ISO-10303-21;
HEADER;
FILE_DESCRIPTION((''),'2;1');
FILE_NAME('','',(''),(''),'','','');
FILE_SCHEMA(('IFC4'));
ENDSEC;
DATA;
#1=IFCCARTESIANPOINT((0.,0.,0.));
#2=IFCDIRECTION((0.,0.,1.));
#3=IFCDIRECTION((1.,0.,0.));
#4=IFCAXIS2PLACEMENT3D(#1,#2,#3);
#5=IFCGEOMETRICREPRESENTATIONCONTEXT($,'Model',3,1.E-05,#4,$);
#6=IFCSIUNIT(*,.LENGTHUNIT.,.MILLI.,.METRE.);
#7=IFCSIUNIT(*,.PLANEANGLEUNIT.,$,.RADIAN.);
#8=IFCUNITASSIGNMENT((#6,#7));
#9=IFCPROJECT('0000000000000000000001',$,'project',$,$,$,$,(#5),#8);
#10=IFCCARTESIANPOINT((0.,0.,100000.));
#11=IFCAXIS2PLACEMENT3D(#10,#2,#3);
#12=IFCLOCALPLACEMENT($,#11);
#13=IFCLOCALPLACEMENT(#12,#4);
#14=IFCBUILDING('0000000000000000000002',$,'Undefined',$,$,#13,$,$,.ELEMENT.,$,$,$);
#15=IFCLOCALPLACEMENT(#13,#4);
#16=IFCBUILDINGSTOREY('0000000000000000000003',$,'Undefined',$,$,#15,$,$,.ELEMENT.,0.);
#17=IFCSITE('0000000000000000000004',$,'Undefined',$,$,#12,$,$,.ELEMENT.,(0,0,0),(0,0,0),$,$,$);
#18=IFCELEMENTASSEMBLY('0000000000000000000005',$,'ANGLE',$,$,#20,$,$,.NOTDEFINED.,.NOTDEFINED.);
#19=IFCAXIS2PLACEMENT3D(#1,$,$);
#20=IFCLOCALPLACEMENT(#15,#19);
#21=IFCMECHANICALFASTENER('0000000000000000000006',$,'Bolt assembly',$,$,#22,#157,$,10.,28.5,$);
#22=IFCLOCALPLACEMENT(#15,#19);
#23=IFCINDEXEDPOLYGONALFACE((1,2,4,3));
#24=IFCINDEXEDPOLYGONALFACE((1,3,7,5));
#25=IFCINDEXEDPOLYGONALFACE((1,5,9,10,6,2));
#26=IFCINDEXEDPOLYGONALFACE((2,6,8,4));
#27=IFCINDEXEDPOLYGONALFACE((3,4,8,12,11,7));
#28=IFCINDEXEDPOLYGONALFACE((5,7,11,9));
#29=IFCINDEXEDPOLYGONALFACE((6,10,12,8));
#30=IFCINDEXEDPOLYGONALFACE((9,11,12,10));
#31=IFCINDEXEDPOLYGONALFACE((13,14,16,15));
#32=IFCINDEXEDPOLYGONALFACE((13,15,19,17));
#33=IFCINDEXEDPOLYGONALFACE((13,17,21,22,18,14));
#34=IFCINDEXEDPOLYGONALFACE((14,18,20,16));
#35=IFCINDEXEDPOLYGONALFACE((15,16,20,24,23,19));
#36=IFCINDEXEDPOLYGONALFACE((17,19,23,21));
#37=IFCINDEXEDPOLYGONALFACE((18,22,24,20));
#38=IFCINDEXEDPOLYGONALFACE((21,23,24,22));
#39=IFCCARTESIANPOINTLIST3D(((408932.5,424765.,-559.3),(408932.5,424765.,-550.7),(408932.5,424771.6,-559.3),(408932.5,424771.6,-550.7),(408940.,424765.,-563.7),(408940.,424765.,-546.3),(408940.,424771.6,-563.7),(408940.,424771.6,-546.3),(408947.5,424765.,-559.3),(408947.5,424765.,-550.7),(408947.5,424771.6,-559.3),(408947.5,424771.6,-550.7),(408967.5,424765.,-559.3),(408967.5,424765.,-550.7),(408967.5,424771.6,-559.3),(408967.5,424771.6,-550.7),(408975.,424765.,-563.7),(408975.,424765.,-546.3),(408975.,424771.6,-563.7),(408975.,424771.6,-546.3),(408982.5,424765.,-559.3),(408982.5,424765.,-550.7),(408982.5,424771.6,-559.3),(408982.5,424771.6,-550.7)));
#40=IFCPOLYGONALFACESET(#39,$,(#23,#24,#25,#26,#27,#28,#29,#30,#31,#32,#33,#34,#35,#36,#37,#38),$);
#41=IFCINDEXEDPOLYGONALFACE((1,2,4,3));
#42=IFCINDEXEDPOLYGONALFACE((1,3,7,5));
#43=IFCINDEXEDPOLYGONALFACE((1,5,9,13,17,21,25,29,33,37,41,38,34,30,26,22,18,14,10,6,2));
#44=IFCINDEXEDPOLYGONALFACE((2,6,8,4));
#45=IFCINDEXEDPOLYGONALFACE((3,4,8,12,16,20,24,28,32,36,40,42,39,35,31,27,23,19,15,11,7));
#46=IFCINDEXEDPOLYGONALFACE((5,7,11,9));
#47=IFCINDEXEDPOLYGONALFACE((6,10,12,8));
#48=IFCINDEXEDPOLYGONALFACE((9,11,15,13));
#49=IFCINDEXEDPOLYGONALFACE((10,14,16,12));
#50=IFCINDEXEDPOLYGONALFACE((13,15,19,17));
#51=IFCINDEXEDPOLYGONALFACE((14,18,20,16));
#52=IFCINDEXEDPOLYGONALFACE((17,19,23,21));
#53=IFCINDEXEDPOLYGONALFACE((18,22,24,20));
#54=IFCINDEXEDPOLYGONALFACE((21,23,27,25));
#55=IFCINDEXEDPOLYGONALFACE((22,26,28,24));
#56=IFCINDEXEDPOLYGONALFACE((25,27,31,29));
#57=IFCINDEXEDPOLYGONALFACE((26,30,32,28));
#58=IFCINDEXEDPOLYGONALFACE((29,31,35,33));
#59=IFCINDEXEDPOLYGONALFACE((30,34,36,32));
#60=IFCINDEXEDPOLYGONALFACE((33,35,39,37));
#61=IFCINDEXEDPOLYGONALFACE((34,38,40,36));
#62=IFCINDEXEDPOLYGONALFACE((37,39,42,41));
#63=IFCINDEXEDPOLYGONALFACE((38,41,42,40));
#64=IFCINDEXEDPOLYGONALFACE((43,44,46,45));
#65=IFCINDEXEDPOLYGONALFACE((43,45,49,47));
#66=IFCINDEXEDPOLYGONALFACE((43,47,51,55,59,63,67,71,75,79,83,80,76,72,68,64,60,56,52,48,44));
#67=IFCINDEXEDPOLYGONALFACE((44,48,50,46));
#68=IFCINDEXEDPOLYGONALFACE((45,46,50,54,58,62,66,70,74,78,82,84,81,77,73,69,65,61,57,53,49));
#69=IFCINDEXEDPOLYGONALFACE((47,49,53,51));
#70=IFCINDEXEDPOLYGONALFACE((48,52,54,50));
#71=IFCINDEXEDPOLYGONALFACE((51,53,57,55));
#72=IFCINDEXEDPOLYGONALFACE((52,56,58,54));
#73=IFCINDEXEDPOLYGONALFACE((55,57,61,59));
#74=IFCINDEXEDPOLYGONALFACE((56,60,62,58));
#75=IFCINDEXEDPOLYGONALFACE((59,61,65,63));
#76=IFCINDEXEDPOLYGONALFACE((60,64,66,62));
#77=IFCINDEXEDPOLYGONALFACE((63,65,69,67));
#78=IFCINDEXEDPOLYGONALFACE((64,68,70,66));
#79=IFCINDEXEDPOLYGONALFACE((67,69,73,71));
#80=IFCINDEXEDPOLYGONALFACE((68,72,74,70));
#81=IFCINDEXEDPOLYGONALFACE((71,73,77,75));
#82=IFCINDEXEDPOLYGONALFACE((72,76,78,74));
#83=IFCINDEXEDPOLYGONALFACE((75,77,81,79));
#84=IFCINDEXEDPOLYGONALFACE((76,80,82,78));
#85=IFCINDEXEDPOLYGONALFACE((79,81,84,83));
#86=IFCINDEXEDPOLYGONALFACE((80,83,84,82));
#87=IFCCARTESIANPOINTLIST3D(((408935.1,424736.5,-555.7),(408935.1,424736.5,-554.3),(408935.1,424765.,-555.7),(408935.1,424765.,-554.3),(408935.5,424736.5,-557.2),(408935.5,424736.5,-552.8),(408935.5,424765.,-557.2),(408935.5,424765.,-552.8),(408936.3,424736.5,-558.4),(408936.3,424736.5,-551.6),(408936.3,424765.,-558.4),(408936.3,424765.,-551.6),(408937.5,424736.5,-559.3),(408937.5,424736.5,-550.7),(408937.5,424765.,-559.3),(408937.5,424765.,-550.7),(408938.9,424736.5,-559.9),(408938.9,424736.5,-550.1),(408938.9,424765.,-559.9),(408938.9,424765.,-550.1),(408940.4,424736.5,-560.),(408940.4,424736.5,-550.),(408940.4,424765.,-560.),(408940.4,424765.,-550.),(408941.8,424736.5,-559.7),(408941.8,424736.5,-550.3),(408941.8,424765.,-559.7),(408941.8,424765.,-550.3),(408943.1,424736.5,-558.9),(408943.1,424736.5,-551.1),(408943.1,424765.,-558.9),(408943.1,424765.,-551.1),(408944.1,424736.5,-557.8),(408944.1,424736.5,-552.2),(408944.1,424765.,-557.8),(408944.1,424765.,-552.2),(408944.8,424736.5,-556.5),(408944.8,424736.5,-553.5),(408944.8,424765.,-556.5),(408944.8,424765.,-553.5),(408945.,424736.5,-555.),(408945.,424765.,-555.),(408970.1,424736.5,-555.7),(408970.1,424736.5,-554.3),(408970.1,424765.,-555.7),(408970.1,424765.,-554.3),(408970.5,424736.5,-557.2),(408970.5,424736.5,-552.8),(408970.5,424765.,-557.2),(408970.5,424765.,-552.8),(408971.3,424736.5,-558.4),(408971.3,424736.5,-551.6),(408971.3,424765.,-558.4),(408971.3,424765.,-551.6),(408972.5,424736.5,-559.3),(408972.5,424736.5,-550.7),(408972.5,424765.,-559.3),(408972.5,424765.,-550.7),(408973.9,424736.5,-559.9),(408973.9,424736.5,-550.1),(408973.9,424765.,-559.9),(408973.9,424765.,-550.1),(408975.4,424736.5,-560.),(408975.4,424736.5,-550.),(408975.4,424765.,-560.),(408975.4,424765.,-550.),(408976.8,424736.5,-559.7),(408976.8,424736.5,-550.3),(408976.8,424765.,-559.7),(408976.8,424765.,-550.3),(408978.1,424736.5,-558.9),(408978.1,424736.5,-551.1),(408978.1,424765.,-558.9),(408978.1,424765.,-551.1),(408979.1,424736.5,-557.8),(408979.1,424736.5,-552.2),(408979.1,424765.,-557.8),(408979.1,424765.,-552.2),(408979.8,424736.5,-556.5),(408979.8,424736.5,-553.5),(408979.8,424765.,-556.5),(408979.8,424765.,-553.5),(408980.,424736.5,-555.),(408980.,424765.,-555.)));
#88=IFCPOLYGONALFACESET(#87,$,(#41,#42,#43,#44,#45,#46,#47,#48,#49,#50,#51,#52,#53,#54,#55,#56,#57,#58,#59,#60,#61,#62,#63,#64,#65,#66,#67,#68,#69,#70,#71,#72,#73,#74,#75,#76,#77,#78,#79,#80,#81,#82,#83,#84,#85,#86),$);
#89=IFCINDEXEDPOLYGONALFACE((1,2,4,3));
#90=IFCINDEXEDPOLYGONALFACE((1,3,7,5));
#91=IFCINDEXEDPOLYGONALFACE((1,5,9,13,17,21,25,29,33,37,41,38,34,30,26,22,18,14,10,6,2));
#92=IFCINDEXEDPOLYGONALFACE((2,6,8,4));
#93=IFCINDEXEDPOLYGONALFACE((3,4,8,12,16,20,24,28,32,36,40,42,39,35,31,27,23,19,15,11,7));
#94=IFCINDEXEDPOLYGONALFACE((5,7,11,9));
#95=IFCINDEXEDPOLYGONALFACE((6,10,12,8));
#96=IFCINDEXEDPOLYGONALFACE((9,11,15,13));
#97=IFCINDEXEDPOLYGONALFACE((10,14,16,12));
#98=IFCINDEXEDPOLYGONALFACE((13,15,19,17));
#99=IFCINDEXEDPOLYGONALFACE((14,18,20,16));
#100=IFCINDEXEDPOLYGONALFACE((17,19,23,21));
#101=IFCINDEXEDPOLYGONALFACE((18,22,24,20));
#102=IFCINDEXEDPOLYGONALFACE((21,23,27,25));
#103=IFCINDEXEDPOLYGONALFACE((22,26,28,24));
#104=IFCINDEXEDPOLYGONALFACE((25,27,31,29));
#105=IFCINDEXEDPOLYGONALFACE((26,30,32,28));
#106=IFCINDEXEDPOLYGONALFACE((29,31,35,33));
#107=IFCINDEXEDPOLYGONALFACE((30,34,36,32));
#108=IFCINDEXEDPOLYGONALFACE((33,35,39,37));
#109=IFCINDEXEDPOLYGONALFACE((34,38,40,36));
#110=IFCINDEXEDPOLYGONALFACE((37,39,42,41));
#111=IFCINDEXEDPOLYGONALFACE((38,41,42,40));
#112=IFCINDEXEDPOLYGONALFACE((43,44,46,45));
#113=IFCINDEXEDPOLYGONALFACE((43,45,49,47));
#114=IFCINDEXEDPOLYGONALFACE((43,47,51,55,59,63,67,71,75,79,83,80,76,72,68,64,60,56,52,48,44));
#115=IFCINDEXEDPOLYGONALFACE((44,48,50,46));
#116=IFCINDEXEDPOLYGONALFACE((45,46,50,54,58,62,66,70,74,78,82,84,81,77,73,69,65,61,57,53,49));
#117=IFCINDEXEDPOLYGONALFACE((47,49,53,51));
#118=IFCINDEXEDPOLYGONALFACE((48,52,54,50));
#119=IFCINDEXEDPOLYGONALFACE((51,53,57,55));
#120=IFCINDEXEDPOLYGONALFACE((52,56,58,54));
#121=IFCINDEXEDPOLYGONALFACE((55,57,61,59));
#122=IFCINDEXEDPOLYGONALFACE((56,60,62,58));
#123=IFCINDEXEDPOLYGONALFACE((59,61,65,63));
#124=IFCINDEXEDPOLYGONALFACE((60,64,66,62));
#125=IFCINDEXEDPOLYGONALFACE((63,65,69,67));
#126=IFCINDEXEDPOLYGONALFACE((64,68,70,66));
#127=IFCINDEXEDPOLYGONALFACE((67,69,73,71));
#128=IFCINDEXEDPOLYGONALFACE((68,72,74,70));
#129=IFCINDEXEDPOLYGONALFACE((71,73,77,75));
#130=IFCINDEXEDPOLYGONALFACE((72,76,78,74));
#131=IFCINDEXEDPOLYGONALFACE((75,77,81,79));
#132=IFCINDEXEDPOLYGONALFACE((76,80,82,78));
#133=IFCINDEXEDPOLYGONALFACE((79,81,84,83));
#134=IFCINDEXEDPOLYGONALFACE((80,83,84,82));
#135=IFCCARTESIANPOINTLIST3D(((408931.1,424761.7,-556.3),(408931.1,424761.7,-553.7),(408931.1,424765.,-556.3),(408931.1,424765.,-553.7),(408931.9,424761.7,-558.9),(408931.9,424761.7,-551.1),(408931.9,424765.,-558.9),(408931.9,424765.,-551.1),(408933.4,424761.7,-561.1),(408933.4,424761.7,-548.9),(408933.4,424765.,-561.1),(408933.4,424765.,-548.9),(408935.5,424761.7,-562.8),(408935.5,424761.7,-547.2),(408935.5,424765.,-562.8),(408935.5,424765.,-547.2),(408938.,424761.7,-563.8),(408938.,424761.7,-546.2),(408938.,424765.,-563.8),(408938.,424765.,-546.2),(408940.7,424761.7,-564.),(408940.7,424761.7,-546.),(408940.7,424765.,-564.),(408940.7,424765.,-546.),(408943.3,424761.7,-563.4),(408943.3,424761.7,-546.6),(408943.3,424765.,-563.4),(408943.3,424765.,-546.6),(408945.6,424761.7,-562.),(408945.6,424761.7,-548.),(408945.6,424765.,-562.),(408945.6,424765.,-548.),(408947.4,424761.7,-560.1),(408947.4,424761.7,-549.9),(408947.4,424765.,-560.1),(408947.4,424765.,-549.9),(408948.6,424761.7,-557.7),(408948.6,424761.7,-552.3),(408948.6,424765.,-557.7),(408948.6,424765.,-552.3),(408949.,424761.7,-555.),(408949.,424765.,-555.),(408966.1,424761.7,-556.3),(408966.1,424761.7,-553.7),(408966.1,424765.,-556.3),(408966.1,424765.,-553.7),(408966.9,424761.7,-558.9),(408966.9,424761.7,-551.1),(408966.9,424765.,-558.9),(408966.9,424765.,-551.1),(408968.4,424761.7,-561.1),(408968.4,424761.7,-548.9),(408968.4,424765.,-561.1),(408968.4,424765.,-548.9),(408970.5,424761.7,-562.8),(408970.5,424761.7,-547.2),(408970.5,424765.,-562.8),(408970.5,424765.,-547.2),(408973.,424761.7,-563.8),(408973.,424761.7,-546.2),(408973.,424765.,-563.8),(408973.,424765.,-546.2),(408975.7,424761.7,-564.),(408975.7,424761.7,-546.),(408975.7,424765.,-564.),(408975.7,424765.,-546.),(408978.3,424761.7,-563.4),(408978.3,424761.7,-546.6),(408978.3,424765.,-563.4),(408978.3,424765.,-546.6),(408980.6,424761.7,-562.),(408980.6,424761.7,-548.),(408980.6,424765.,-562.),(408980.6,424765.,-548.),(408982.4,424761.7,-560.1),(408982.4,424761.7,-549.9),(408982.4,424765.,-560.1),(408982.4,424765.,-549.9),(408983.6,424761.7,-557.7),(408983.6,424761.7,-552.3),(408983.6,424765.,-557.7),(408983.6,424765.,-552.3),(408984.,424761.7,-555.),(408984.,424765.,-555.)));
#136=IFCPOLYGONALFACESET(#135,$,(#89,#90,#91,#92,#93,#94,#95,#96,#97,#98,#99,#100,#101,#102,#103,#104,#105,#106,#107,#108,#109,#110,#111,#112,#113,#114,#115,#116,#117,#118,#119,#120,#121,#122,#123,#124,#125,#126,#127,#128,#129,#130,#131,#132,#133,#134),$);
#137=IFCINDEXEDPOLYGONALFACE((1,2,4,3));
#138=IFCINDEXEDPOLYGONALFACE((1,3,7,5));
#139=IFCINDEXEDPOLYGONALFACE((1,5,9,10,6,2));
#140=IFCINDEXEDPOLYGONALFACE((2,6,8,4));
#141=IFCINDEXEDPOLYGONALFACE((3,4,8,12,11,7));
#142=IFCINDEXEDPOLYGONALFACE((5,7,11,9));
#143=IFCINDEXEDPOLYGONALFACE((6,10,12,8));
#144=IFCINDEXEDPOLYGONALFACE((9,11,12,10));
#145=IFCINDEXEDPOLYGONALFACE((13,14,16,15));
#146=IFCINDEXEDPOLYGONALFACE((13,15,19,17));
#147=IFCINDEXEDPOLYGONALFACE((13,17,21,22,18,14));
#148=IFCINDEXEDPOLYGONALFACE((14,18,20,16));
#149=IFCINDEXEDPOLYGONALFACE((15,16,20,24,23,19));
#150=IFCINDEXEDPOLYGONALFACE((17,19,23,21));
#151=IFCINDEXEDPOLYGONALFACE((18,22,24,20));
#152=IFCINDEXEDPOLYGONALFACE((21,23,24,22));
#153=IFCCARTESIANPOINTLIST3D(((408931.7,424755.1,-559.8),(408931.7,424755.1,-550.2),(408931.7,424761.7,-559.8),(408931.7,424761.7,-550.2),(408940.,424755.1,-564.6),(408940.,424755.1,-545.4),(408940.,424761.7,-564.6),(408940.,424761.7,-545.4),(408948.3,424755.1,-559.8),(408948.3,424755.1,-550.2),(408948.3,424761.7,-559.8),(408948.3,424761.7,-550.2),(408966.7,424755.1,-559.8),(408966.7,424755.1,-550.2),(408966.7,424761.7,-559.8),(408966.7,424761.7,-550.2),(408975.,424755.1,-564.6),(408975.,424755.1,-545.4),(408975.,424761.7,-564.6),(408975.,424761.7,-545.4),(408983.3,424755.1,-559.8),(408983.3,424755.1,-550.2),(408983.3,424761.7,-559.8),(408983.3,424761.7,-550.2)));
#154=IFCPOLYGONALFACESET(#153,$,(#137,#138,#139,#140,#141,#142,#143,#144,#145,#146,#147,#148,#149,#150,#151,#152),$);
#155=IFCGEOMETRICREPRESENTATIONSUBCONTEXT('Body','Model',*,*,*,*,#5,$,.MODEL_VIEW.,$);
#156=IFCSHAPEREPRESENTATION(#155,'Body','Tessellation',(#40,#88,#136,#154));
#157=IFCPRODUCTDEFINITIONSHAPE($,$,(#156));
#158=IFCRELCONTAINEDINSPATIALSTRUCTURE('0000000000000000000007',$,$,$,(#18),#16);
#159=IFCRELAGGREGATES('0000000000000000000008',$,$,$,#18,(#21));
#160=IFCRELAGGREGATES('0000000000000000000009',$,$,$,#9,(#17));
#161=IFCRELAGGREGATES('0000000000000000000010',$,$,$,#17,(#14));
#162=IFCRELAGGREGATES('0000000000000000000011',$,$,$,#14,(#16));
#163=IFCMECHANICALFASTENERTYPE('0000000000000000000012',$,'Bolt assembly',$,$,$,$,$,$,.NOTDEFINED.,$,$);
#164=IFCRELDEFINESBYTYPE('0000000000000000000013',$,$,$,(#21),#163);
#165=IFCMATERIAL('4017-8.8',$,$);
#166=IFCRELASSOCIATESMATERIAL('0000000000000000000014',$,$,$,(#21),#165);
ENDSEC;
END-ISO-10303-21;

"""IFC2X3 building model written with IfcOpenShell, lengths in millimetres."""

from ifc_helpers import new_model, si_unit, frame, origin_with_axes, origin_2d_with_axis, place, context, subcontext, project, spatial, polyline, circle, outline, extrude, source, transform, mapped, material, type_object, element, aggregate, save


model = new_model("IFC2X3")

# Units and contexts
model_context = context("Model", 3, precision=1e-05, world=origin_with_axes())
body_context = subcontext(model_context, "Body", "Model", "MODEL_VIEW")
ifc_project = project(units=[si_unit("LENGTHUNIT", "METRE", prefix="MILLI"), si_unit("PLANEANGLEUNIT", "RADIAN")], contexts=[model_context])

# Site, building, storey
site_placement = place(None, frame((0.0, 0.0, 100000.0), z_axis=(0.0, 0.0, 1.0), x_axis=(1.0, 0.0, 0.0)))
site = spatial("IfcSite", under=ifc_project, at=site_placement, Name="Undefined", CompositionType="ELEMENT", RefLatitude=(0, 0, 0), RefLongitude=(0, 0, 0))
building_placement = place(site_placement, origin_with_axes())
building = spatial("IfcBuilding", under=site, at=building_placement, Name="Undefined", CompositionType="ELEMENT")
storey_placement = place(building_placement, origin_with_axes())
storey = spatial("IfcBuildingStorey", under=building, at=storey_placement, Name="Undefined", CompositionType="ELEMENT", Elevation=0.0)

# Element assembly
assembly_1_placement = place(storey_placement, origin_with_axes())
assembly_1 = element("IfcElementAssembly", 1, at=assembly_1_placement, inside=storey, Name="ANGLE", AssemblyPlace="NOTDEFINED", PredefinedType="NOTDEFINED")

# Shared definitions
ifc_material_1 = material(Name="4017-8.8")
mechanical_fastener_type = type_object("IfcMechanicalFastenerType", Name="Bolt assembly")

# Mechanical fastener
shared_shape_1 = source(origin_with_axes(), body_context, "Body", "SweptSolid", [
    extrude(outline(polyline([(7.5, -4.3), (7.5, 4.3), (0.0, 8.7), (-7.5, 4.3), (-7.5, -4.3), (0.0, -8.7), (7.5, -4.3)])), frame((0.0, -6.6, 0.0), z_axis=(0.0, 1.0, 0.0), x_axis=(1.0, 0.0, 0.0)), (0.0, 0.0, 1.0), 6.6),
    extrude(circle(Radius=5.0, at=origin_2d_with_axis()), frame((0.0, 0.0, 0.0), z_axis=(0.0, 1.0, 0.0), x_axis=(1.0, 0.0, 0.0)), (0.0, 0.0, 1.0), 28.5),
    extrude(circle(Radius=9.0, at=origin_2d_with_axis()), frame((0.0, 0.0, 0.0), z_axis=(0.0, 1.0, 0.0), x_axis=(1.0, 0.0, 0.0)), (0.0, 0.0, 1.0), 3.3),
    extrude(outline(polyline([(8.3, -4.8), (8.3, 4.8), (0.0, 9.6), (-8.3, 4.8), (-8.3, -4.8), (0.0, -9.6), (8.3, -4.8)])), frame((0.0, 3.3, 0.0), z_axis=(0.0, 1.0, 0.0), x_axis=(1.0, 0.0, 0.0)), (0.0, 0.0, 1.0), 6.6),
])
mechanical_fastener_1_placement = place(assembly_1_placement, frame((408880.0, 424765.0, -520.0), z_axis=(0.0, 0.0, -1.0), x_axis=(1.0, 0.0, 0.0)))
mechanical_fastener_1 = element("IfcMechanicalFastener", 2, at=mechanical_fastener_1_placement, type_object=mechanical_fastener_type, material=ifc_material_1, Name="Bolt assembly", NominalDiameter=10.0, NominalLength=28.5, context=body_context, shape_type="MappedRepresentation", body=[
    mapped(shared_shape_1, transform((95.0, 0.0, 35.0))),
    mapped(shared_shape_1, transform((60.0, 0.0, 35.0))),
])
aggregate(assembly_1, [mechanical_fastener_1])

save(model, "model.ifc")
